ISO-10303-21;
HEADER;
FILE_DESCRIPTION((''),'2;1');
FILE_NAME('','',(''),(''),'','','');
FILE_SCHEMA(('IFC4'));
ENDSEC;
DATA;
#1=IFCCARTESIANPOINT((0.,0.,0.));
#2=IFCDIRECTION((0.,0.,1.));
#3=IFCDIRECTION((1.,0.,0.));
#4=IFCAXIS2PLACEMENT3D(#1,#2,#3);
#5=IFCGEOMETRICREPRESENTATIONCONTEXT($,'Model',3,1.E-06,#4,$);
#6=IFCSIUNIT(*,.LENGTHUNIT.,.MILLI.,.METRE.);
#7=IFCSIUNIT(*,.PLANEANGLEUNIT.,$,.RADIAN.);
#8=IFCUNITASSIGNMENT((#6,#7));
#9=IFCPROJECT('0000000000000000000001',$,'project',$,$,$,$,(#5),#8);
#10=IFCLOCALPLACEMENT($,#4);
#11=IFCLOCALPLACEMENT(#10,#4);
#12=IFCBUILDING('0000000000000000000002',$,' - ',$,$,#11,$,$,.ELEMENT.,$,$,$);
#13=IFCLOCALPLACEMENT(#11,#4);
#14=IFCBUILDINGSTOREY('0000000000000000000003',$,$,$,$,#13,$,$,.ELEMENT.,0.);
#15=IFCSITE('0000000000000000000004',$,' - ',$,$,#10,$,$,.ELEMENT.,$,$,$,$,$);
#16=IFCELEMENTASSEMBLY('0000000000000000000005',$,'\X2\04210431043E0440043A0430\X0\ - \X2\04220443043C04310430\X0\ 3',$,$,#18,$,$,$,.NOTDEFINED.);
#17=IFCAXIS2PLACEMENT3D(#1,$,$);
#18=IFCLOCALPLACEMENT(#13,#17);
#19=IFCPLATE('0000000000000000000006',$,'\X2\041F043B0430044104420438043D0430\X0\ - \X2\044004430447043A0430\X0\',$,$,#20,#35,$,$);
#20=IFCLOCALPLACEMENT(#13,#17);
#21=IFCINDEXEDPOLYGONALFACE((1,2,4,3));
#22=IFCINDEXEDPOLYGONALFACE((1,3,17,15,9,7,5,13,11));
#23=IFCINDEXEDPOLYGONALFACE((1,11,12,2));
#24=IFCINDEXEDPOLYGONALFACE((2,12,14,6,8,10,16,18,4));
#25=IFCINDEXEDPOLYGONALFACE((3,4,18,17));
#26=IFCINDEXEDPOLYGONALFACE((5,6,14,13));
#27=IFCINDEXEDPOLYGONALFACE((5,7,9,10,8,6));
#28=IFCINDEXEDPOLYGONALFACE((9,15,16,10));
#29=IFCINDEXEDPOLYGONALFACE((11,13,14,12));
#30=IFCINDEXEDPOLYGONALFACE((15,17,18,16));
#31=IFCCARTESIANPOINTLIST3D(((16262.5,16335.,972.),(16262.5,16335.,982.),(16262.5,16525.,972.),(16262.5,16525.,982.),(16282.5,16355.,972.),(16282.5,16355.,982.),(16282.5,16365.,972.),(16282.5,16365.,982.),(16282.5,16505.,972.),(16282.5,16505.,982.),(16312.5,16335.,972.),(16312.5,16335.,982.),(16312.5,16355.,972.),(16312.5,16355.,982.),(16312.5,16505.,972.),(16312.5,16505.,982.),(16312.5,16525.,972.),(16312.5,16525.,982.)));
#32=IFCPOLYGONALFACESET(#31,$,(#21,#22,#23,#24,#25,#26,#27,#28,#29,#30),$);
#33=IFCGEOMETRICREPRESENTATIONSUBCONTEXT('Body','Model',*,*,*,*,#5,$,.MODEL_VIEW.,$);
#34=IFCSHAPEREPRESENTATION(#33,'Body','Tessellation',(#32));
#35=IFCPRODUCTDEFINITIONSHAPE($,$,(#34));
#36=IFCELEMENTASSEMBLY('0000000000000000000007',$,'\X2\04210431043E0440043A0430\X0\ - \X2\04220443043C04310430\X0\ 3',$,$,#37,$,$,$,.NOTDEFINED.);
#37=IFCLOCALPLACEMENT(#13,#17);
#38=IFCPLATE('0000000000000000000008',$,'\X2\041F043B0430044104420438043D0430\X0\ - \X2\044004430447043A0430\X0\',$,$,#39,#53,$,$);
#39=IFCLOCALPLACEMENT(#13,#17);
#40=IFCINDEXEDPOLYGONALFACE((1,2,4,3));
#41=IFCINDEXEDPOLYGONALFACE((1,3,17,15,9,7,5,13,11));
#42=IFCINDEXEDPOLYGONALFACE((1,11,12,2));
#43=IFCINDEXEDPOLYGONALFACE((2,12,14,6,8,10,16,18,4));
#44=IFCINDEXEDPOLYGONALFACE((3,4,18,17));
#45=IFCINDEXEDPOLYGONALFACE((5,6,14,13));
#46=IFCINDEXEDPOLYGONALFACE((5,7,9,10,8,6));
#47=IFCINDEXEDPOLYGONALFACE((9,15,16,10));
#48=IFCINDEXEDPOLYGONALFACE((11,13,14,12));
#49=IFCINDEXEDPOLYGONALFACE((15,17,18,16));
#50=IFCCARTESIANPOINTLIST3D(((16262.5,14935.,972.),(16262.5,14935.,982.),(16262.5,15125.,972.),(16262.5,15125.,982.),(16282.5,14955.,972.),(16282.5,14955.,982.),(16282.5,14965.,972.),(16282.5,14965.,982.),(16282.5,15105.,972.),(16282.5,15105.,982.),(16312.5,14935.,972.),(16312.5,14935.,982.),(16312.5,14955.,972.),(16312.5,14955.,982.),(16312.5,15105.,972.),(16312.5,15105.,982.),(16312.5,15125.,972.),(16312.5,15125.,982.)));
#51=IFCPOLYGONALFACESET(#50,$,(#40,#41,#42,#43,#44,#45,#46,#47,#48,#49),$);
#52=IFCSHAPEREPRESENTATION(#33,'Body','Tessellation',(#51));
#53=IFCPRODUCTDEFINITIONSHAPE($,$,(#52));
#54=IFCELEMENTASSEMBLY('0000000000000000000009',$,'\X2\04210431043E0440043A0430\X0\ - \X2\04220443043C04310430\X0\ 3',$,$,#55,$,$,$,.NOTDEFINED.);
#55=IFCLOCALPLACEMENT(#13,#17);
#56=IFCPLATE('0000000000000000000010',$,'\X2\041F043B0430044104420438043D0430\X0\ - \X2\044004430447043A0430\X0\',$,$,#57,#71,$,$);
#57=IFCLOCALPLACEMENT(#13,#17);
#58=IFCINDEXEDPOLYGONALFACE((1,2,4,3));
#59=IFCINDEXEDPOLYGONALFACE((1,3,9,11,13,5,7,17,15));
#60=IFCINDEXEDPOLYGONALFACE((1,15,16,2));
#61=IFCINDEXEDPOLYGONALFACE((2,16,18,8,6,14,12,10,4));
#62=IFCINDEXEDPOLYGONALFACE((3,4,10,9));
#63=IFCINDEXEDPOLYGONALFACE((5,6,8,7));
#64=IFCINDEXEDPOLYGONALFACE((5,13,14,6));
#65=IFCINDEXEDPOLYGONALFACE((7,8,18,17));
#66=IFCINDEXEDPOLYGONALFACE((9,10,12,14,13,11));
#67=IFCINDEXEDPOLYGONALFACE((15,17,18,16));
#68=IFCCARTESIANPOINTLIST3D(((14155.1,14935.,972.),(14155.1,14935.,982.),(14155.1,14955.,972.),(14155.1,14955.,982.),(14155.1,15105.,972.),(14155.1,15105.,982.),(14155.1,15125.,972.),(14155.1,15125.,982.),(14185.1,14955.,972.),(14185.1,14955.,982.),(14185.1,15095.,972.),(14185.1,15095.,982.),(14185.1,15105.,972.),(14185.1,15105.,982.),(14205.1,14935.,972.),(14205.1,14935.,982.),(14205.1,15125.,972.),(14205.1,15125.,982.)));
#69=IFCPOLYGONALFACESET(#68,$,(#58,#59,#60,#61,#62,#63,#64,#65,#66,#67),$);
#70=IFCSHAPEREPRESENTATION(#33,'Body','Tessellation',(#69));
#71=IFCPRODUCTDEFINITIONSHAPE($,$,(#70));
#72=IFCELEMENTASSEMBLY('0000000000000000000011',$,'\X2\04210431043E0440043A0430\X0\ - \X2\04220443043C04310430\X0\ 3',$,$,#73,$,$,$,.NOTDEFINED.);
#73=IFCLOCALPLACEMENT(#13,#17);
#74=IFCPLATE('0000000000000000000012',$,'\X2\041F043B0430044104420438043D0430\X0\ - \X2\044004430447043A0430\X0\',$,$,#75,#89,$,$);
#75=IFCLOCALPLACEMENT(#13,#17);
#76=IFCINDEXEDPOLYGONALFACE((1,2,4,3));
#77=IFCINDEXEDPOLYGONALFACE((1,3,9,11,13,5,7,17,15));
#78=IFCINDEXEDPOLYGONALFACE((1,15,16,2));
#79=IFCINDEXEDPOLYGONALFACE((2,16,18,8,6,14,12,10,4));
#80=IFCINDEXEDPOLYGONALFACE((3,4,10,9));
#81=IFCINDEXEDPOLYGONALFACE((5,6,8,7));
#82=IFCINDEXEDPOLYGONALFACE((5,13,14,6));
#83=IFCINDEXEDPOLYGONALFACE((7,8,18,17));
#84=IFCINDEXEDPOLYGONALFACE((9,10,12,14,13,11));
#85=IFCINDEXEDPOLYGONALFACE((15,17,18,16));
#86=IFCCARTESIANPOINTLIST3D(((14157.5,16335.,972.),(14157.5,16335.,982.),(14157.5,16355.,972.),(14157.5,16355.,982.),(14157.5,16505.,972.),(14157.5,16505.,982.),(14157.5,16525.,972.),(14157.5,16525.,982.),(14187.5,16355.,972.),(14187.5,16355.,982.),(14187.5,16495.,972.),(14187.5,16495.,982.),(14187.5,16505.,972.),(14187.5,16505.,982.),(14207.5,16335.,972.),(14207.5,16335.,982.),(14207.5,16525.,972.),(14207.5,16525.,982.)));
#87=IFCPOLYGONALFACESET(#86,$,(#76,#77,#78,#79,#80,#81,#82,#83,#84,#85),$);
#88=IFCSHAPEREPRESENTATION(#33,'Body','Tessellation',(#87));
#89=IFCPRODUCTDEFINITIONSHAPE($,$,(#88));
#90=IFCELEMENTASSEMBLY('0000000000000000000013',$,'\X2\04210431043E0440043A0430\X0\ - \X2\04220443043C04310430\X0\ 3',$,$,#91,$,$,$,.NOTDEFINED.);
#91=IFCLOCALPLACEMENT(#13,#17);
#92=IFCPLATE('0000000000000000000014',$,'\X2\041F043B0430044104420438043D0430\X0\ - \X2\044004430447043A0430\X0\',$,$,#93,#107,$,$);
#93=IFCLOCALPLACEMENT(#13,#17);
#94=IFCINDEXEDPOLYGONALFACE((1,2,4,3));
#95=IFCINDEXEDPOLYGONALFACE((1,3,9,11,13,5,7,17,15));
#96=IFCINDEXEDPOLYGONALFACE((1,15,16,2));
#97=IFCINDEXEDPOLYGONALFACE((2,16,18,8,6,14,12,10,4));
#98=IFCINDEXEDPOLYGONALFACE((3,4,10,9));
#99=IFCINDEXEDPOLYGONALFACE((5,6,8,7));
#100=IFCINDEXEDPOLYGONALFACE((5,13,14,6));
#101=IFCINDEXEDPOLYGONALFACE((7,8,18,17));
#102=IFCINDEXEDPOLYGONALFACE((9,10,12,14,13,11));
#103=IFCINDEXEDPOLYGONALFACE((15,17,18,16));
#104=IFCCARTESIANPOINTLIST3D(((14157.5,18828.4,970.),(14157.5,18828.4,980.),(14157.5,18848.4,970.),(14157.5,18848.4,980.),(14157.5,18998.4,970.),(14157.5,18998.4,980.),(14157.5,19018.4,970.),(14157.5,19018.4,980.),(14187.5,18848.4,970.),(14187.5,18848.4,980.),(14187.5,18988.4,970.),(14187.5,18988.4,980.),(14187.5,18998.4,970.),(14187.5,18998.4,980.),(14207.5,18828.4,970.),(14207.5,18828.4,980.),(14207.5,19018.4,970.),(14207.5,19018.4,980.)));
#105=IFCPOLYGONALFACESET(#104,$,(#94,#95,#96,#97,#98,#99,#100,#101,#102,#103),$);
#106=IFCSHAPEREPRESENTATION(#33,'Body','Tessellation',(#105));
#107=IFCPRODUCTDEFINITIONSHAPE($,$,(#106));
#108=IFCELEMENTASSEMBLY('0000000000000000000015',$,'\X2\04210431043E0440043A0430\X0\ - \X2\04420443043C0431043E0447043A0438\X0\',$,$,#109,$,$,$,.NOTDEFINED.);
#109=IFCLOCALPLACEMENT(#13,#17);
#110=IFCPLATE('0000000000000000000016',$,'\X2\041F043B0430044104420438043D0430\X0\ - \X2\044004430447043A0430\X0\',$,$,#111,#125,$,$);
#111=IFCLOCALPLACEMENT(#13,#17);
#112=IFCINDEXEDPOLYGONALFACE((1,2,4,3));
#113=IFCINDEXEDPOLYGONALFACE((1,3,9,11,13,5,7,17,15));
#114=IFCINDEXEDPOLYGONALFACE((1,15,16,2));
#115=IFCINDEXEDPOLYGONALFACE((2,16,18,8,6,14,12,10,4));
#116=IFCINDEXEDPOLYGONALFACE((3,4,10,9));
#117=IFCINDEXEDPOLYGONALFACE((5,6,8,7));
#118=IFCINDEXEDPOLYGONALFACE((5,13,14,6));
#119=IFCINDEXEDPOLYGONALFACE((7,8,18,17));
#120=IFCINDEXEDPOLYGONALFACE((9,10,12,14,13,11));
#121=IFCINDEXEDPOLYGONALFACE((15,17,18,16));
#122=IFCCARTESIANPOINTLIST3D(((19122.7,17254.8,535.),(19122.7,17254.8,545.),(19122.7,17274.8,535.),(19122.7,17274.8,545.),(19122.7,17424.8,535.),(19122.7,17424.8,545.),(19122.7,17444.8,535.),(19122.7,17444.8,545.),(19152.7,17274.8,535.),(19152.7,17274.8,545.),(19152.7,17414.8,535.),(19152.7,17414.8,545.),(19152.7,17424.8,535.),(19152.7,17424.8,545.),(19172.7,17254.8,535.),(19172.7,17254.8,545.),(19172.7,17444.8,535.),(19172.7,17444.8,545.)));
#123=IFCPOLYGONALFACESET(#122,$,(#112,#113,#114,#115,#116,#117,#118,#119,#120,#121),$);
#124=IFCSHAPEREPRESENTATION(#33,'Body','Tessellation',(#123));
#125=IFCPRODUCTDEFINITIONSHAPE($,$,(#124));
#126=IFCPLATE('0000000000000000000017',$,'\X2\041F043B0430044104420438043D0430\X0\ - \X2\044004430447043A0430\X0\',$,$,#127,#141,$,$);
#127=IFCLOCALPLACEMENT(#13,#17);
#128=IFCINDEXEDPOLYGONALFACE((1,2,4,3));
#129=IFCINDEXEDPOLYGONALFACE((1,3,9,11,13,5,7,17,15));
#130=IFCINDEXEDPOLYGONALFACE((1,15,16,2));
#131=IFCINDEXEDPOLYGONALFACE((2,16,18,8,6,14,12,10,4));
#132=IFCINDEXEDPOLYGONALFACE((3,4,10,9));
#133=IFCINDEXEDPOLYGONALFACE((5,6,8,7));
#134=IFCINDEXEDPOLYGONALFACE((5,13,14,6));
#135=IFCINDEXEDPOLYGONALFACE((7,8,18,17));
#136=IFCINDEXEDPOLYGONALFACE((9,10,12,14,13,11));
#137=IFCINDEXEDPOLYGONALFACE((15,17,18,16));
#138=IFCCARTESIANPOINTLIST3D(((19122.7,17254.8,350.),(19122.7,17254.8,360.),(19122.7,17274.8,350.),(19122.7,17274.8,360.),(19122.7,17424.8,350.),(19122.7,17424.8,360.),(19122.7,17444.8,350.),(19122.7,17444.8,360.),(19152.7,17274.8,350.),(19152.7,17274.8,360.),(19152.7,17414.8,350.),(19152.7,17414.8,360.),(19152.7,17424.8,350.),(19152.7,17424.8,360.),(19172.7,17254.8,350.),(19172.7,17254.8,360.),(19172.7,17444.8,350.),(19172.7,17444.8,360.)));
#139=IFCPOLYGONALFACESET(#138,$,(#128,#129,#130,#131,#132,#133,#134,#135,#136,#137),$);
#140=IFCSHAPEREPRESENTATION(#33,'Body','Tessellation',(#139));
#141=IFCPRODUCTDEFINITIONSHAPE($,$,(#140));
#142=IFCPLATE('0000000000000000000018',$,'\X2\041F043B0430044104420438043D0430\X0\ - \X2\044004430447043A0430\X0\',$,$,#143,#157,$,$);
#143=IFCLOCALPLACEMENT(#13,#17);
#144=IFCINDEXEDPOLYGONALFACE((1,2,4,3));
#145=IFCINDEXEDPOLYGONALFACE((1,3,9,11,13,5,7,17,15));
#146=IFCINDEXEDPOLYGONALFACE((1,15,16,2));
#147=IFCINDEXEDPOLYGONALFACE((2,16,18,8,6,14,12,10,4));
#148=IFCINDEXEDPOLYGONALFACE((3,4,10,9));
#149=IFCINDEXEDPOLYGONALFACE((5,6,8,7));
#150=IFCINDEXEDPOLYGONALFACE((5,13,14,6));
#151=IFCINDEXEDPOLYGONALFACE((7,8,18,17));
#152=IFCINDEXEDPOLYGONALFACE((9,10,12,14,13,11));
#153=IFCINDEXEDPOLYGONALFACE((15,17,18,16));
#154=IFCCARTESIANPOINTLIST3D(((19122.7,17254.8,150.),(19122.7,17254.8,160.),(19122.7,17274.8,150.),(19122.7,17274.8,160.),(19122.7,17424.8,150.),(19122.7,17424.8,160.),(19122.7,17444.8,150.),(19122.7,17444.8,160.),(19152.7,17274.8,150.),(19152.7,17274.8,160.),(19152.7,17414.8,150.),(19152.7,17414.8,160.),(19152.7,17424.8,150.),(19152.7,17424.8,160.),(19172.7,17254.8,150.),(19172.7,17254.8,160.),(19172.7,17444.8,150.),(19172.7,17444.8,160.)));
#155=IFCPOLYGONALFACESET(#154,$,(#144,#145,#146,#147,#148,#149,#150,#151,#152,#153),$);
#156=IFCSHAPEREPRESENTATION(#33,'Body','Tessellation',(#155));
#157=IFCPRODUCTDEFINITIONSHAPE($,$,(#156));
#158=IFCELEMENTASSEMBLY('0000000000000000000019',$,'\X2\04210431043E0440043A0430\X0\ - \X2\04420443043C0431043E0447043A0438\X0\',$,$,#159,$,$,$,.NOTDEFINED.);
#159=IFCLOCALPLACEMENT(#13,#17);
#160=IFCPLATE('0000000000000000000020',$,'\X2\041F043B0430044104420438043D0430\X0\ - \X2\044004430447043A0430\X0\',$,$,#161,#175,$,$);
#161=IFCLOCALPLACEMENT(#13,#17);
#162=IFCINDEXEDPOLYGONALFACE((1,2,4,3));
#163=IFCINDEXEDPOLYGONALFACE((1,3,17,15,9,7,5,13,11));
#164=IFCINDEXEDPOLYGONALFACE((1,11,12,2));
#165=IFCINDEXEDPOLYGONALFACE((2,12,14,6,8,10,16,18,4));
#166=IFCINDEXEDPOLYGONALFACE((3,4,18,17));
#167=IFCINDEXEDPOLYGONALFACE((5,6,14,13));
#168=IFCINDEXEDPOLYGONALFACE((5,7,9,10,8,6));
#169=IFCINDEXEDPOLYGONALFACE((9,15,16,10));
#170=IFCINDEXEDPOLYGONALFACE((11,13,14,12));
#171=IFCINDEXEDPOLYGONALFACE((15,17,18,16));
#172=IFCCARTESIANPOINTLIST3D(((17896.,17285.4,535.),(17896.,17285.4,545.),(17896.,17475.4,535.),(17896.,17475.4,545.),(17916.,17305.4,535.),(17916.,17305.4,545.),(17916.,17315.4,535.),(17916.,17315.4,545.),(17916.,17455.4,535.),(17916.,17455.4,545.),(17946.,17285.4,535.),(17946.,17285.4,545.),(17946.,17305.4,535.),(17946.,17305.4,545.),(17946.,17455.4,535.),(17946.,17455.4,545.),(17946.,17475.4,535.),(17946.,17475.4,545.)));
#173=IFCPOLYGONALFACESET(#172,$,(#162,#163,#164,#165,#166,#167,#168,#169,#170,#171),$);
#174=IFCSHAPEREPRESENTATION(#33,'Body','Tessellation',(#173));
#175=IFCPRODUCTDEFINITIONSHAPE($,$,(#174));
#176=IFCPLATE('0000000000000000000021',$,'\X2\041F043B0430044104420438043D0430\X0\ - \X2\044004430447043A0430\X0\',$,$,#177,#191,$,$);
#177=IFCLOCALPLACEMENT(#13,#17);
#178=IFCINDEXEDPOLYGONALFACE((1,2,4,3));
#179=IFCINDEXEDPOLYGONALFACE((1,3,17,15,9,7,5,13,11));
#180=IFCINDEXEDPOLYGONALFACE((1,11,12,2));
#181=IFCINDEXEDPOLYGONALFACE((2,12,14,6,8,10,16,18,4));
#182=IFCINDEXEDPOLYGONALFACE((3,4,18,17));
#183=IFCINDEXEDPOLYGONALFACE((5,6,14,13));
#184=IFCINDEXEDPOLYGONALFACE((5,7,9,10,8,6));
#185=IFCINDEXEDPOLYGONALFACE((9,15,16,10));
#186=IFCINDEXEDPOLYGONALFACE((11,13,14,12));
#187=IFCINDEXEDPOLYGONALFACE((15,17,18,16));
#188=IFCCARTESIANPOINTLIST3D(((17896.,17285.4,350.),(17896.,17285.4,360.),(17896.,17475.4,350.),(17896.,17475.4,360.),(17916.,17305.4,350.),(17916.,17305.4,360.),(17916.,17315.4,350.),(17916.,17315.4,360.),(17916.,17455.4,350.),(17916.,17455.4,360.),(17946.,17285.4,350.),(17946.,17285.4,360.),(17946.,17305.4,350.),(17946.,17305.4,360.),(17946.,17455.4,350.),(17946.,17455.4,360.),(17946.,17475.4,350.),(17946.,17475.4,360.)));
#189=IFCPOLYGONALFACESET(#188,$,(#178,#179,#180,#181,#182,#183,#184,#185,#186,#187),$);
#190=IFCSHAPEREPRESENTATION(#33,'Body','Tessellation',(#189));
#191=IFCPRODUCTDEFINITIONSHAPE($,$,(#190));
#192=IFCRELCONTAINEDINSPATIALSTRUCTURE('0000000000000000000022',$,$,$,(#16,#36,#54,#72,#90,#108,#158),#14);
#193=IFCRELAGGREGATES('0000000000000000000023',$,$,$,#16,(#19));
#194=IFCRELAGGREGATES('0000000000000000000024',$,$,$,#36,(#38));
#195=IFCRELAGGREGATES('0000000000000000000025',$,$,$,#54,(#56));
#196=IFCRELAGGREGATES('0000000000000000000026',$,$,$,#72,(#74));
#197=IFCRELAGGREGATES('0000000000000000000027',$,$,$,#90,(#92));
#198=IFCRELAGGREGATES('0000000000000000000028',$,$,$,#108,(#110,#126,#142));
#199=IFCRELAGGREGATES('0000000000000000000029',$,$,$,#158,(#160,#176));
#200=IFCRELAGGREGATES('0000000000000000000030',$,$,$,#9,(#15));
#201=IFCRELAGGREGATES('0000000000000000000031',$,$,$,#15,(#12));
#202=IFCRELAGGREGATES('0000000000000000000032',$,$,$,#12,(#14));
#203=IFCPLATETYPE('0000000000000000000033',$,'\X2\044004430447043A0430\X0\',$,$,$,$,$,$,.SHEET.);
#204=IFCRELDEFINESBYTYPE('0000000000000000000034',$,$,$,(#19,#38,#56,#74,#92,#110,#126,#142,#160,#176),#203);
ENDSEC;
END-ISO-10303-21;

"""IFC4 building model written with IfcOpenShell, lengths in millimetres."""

from ifc_helpers import new_model, si_unit, frame, origin_with_axes, place, context, subcontext, project, spatial, line, indexed_curve, outline, extrude, source, transform, mapped, type_object, element, aggregate, save


model = new_model("IFC4")

# Units and contexts
model_context = context("Model", 3, precision=1e-06, world=origin_with_axes())
body_context = subcontext(model_context, "Body", "Model", "MODEL_VIEW")
ifc_project = project(units=[si_unit("LENGTHUNIT", "METRE", prefix="MILLI"), si_unit("PLANEANGLEUNIT", "RADIAN")], contexts=[model_context])

# Site, building, storey
site_placement = place(None, origin_with_axes())
site = spatial("IfcSite", under=ifc_project, at=site_placement, Name=" - ", CompositionType="ELEMENT")
building_placement = place(site_placement, origin_with_axes())
building = spatial("IfcBuilding", under=site, at=building_placement, Name=" - ", CompositionType="ELEMENT")
storey_placement = place(building_placement, origin_with_axes())
storey = spatial("IfcBuildingStorey", under=building, at=storey_placement, CompositionType="ELEMENT", Elevation=0.0)

# Element assemblies, plates
assembly_1_placement = place(storey_placement, frame((16502.5, 16430.0, 2.0), z_axis=(0.0, 0.0, 1.0), x_axis=(0.0, -1.0, 0.0)))
assembly_1 = element("IfcElementAssembly", 1, at=assembly_1_placement, inside=storey, Name="Сборка - Тумба 3", PredefinedType="NOTDEFINED")
plate_type = type_object("IfcPlateType", Name="ручка", PredefinedType="SHEET")
shared_shape = source(origin_with_axes(), body_context, "Body", "SweptSolid", [
    extrude(outline(indexed_curve([(-95.0, -25.0), (-75.0, -25.0), (-75.0, 5.0), (-65.0, 5.0), (75.0, 5.0), (75.0, -25.0), (95.0, -25.0), (95.0, 25.0), (-95.0, 25.0)], segments=[line(1, 2), line(2, 3), line(3, 4), line(4, 5), line(5, 6), line(6, 7), line(7, 8), line(8, 9), line(9, 1)])), origin_with_axes(), (0.0, 0.0, 1.0), 10.0),
])
plate_1_placement = place(assembly_1_placement, frame((0.0, -215.0, 970.0), z_axis=(0.0, 0.0, 1.0), x_axis=(-1.0, 0.0, 0.0)))
plate_1 = element("IfcPlate", 2, at=plate_1_placement, type_object=plate_type, Name="Пластина - ручка", context=body_context, shape_type="MappedRepresentation", body=[
    mapped(shared_shape, transform((0.0, 0.0, 0.0), x_axis=(1.0, 0.0, 0.0), y_axis=(0.0, 1.0, 0.0), z_axis=(0.0, 0.0, 1.0), scale=1.0)),
])
aggregate(assembly_1, [plate_1])
assembly_2_placement = place(storey_placement, frame((16502.5, 15030.0, 2.0), z_axis=(0.0, 0.0, 1.0), x_axis=(0.0, -1.0, 0.0)))
assembly_2 = element("IfcElementAssembly", 3, at=assembly_2_placement, inside=storey, Name="Сборка - Тумба 3", PredefinedType="NOTDEFINED")
plate_2_placement = place(assembly_2_placement, frame((0.0, -215.0, 970.0), z_axis=(0.0, 0.0, 1.0), x_axis=(-1.0, 0.0, 0.0)))
plate_2 = element("IfcPlate", 4, at=plate_2_placement, type_object=plate_type, Name="Пластина - ручка", context=body_context, shape_type="MappedRepresentation", body=[
    mapped(shared_shape, transform((0.0, 0.0, 0.0), x_axis=(1.0, 0.0, 0.0), y_axis=(0.0, 1.0, 0.0), z_axis=(0.0, 0.0, 1.0), scale=1.0)),
])
aggregate(assembly_2, [plate_2])
assembly_3_placement = place(storey_placement, frame((13965.1, 15030.0, 2.0), z_axis=(0.0, 0.0, 1.0), x_axis=(0.0, 1.0, 0.0)))
assembly_3 = element("IfcElementAssembly", 5, at=assembly_3_placement, inside=storey, Name="Сборка - Тумба 3", PredefinedType="NOTDEFINED")
plate_3_placement = place(assembly_3_placement, frame((0.0, -215.0, 970.0), z_axis=(0.0, 0.0, 1.0), x_axis=(-1.0, 0.0, 0.0)))
plate_3 = element("IfcPlate", 6, at=plate_3_placement, type_object=plate_type, Name="Пластина - ручка", context=body_context, shape_type="MappedRepresentation", body=[
    mapped(shared_shape, transform((0.0, 0.0, 0.0), x_axis=(1.0, 0.0, 0.0), y_axis=(0.0, 1.0, 0.0), z_axis=(0.0, 0.0, 1.0), scale=1.0)),
])
aggregate(assembly_3, [plate_3])
assembly_4_placement = place(storey_placement, frame((13967.5, 16430.0, 2.0), z_axis=(0.0, 0.0, 1.0), x_axis=(0.0, 1.0, 0.0)))
assembly_4 = element("IfcElementAssembly", 7, at=assembly_4_placement, inside=storey, Name="Сборка - Тумба 3", PredefinedType="NOTDEFINED")
plate_4_placement = place(assembly_4_placement, frame((0.0, -215.0, 970.0), z_axis=(0.0, 0.0, 1.0), x_axis=(-1.0, 0.0, 0.0)))
plate_4 = element("IfcPlate", 8, at=plate_4_placement, type_object=plate_type, Name="Пластина - ручка", context=body_context, shape_type="MappedRepresentation", body=[
    mapped(shared_shape, transform((0.0, 0.0, 0.0), x_axis=(1.0, 0.0, 0.0), y_axis=(0.0, 1.0, 0.0), z_axis=(0.0, 0.0, 1.0), scale=1.0)),
])
aggregate(assembly_4, [plate_4])

# Element assembly, plate
assembly_5_placement = place(storey_placement, frame((13967.5, 19398.4, 0.0), z_axis=(0.0, 0.0, 1.0), x_axis=(0.0, 1.0, 0.0)))
assembly_5 = element("IfcElementAssembly", 9, at=assembly_5_placement, inside=storey, Name="Сборка - Тумба 3", PredefinedType="NOTDEFINED")
plate_5_placement = place(assembly_5_placement, frame((-475.0, -215.0, 970.0), z_axis=(0.0, 0.0, 1.0), x_axis=(-1.0, 0.0, 0.0)))
plate_5 = element("IfcPlate", 10, at=plate_5_placement, type_object=plate_type, Name="Пластина - ручка", context=body_context, shape_type="MappedRepresentation", body=[
    mapped(shared_shape, transform((0.0, 0.0, 0.0), x_axis=(1.0, 0.0, 0.0), y_axis=(0.0, 1.0, 0.0), z_axis=(0.0, 0.0, 1.0), scale=1.0)),
])
aggregate(assembly_5, [plate_5])

# Element assemblies, plates
assembly_6_placement = place(storey_placement, frame((19122.7, 17149.8, 0.0), z_axis=(0.0, 0.0, 1.0), x_axis=(0.0, 1.0, 0.0)))
assembly_6 = element("IfcElementAssembly", 11, at=assembly_6_placement, inside=storey, Name="Сборка - тумбочки", PredefinedType="NOTDEFINED")
plate_6_placement = place(assembly_6_placement, frame((200.0, -25.0, 535.0), z_axis=(0.0, 0.0, 1.0), x_axis=(-1.0, 0.0, 0.0)))
plate_6 = element("IfcPlate", 12, at=plate_6_placement, type_object=plate_type, Name="Пластина - ручка", context=body_context, shape_type="MappedRepresentation", body=[
    mapped(shared_shape, transform((0.0, 0.0, 0.0), x_axis=(1.0, 0.0, 0.0), y_axis=(0.0, 1.0, 0.0), z_axis=(0.0, 0.0, 1.0), scale=1.0)),
])
plate_7_placement = place(assembly_6_placement, frame((200.0, -25.0, 350.0), z_axis=(0.0, 0.0, 1.0), x_axis=(-1.0, 0.0, 0.0)))
plate_7 = element("IfcPlate", 13, at=plate_7_placement, type_object=plate_type, Name="Пластина - ручка", context=body_context, shape_type="MappedRepresentation", body=[
    mapped(shared_shape, transform((0.0, 0.0, 0.0), x_axis=(1.0, 0.0, 0.0), y_axis=(0.0, 1.0, 0.0), z_axis=(0.0, 0.0, 1.0), scale=1.0)),
])
plate_8_placement = place(assembly_6_placement, frame((200.0, -25.0, 150.0), z_axis=(0.0, 0.0, 1.0), x_axis=(-1.0, 0.0, 0.0)))
plate_8 = element("IfcPlate", 14, at=plate_8_placement, type_object=plate_type, Name="Пластина - ручка", context=body_context, shape_type="MappedRepresentation", body=[
    mapped(shared_shape, transform((0.0, 0.0, 0.0), x_axis=(1.0, 0.0, 0.0), y_axis=(0.0, 1.0, 0.0), z_axis=(0.0, 0.0, 1.0), scale=1.0)),
])
aggregate(assembly_6, [plate_6, plate_7, plate_8])
assembly_7_placement = place(storey_placement, frame((17946.0, 17580.4, 0.0), z_axis=(0.0, 0.0, 1.0), x_axis=(0.0, -1.0, 0.0)))
assembly_7 = element("IfcElementAssembly", 15, at=assembly_7_placement, inside=storey, Name="Сборка - тумбочки", PredefinedType="NOTDEFINED")
plate_9_placement = place(assembly_7_placement, frame((200.0, -25.0, 535.0), z_axis=(0.0, 0.0, 1.0), x_axis=(-1.0, 0.0, 0.0)))
plate_9 = element("IfcPlate", 16, at=plate_9_placement, type_object=plate_type, Name="Пластина - ручка", context=body_context, shape_type="MappedRepresentation", body=[
    mapped(shared_shape, transform((0.0, 0.0, 0.0), x_axis=(1.0, 0.0, 0.0), y_axis=(0.0, 1.0, 0.0), z_axis=(0.0, 0.0, 1.0), scale=1.0)),
])
plate_10_placement = place(assembly_7_placement, frame((200.0, -25.0, 350.0), z_axis=(0.0, 0.0, 1.0), x_axis=(-1.0, 0.0, 0.0)))
plate_10 = element("IfcPlate", 17, at=plate_10_placement, type_object=plate_type, Name="Пластина - ручка", context=body_context, shape_type="MappedRepresentation", body=[
    mapped(shared_shape, transform((0.0, 0.0, 0.0), x_axis=(1.0, 0.0, 0.0), y_axis=(0.0, 1.0, 0.0), z_axis=(0.0, 0.0, 1.0), scale=1.0)),
])
aggregate(assembly_7, [plate_9, plate_10])

save(model, "model.ifc")
